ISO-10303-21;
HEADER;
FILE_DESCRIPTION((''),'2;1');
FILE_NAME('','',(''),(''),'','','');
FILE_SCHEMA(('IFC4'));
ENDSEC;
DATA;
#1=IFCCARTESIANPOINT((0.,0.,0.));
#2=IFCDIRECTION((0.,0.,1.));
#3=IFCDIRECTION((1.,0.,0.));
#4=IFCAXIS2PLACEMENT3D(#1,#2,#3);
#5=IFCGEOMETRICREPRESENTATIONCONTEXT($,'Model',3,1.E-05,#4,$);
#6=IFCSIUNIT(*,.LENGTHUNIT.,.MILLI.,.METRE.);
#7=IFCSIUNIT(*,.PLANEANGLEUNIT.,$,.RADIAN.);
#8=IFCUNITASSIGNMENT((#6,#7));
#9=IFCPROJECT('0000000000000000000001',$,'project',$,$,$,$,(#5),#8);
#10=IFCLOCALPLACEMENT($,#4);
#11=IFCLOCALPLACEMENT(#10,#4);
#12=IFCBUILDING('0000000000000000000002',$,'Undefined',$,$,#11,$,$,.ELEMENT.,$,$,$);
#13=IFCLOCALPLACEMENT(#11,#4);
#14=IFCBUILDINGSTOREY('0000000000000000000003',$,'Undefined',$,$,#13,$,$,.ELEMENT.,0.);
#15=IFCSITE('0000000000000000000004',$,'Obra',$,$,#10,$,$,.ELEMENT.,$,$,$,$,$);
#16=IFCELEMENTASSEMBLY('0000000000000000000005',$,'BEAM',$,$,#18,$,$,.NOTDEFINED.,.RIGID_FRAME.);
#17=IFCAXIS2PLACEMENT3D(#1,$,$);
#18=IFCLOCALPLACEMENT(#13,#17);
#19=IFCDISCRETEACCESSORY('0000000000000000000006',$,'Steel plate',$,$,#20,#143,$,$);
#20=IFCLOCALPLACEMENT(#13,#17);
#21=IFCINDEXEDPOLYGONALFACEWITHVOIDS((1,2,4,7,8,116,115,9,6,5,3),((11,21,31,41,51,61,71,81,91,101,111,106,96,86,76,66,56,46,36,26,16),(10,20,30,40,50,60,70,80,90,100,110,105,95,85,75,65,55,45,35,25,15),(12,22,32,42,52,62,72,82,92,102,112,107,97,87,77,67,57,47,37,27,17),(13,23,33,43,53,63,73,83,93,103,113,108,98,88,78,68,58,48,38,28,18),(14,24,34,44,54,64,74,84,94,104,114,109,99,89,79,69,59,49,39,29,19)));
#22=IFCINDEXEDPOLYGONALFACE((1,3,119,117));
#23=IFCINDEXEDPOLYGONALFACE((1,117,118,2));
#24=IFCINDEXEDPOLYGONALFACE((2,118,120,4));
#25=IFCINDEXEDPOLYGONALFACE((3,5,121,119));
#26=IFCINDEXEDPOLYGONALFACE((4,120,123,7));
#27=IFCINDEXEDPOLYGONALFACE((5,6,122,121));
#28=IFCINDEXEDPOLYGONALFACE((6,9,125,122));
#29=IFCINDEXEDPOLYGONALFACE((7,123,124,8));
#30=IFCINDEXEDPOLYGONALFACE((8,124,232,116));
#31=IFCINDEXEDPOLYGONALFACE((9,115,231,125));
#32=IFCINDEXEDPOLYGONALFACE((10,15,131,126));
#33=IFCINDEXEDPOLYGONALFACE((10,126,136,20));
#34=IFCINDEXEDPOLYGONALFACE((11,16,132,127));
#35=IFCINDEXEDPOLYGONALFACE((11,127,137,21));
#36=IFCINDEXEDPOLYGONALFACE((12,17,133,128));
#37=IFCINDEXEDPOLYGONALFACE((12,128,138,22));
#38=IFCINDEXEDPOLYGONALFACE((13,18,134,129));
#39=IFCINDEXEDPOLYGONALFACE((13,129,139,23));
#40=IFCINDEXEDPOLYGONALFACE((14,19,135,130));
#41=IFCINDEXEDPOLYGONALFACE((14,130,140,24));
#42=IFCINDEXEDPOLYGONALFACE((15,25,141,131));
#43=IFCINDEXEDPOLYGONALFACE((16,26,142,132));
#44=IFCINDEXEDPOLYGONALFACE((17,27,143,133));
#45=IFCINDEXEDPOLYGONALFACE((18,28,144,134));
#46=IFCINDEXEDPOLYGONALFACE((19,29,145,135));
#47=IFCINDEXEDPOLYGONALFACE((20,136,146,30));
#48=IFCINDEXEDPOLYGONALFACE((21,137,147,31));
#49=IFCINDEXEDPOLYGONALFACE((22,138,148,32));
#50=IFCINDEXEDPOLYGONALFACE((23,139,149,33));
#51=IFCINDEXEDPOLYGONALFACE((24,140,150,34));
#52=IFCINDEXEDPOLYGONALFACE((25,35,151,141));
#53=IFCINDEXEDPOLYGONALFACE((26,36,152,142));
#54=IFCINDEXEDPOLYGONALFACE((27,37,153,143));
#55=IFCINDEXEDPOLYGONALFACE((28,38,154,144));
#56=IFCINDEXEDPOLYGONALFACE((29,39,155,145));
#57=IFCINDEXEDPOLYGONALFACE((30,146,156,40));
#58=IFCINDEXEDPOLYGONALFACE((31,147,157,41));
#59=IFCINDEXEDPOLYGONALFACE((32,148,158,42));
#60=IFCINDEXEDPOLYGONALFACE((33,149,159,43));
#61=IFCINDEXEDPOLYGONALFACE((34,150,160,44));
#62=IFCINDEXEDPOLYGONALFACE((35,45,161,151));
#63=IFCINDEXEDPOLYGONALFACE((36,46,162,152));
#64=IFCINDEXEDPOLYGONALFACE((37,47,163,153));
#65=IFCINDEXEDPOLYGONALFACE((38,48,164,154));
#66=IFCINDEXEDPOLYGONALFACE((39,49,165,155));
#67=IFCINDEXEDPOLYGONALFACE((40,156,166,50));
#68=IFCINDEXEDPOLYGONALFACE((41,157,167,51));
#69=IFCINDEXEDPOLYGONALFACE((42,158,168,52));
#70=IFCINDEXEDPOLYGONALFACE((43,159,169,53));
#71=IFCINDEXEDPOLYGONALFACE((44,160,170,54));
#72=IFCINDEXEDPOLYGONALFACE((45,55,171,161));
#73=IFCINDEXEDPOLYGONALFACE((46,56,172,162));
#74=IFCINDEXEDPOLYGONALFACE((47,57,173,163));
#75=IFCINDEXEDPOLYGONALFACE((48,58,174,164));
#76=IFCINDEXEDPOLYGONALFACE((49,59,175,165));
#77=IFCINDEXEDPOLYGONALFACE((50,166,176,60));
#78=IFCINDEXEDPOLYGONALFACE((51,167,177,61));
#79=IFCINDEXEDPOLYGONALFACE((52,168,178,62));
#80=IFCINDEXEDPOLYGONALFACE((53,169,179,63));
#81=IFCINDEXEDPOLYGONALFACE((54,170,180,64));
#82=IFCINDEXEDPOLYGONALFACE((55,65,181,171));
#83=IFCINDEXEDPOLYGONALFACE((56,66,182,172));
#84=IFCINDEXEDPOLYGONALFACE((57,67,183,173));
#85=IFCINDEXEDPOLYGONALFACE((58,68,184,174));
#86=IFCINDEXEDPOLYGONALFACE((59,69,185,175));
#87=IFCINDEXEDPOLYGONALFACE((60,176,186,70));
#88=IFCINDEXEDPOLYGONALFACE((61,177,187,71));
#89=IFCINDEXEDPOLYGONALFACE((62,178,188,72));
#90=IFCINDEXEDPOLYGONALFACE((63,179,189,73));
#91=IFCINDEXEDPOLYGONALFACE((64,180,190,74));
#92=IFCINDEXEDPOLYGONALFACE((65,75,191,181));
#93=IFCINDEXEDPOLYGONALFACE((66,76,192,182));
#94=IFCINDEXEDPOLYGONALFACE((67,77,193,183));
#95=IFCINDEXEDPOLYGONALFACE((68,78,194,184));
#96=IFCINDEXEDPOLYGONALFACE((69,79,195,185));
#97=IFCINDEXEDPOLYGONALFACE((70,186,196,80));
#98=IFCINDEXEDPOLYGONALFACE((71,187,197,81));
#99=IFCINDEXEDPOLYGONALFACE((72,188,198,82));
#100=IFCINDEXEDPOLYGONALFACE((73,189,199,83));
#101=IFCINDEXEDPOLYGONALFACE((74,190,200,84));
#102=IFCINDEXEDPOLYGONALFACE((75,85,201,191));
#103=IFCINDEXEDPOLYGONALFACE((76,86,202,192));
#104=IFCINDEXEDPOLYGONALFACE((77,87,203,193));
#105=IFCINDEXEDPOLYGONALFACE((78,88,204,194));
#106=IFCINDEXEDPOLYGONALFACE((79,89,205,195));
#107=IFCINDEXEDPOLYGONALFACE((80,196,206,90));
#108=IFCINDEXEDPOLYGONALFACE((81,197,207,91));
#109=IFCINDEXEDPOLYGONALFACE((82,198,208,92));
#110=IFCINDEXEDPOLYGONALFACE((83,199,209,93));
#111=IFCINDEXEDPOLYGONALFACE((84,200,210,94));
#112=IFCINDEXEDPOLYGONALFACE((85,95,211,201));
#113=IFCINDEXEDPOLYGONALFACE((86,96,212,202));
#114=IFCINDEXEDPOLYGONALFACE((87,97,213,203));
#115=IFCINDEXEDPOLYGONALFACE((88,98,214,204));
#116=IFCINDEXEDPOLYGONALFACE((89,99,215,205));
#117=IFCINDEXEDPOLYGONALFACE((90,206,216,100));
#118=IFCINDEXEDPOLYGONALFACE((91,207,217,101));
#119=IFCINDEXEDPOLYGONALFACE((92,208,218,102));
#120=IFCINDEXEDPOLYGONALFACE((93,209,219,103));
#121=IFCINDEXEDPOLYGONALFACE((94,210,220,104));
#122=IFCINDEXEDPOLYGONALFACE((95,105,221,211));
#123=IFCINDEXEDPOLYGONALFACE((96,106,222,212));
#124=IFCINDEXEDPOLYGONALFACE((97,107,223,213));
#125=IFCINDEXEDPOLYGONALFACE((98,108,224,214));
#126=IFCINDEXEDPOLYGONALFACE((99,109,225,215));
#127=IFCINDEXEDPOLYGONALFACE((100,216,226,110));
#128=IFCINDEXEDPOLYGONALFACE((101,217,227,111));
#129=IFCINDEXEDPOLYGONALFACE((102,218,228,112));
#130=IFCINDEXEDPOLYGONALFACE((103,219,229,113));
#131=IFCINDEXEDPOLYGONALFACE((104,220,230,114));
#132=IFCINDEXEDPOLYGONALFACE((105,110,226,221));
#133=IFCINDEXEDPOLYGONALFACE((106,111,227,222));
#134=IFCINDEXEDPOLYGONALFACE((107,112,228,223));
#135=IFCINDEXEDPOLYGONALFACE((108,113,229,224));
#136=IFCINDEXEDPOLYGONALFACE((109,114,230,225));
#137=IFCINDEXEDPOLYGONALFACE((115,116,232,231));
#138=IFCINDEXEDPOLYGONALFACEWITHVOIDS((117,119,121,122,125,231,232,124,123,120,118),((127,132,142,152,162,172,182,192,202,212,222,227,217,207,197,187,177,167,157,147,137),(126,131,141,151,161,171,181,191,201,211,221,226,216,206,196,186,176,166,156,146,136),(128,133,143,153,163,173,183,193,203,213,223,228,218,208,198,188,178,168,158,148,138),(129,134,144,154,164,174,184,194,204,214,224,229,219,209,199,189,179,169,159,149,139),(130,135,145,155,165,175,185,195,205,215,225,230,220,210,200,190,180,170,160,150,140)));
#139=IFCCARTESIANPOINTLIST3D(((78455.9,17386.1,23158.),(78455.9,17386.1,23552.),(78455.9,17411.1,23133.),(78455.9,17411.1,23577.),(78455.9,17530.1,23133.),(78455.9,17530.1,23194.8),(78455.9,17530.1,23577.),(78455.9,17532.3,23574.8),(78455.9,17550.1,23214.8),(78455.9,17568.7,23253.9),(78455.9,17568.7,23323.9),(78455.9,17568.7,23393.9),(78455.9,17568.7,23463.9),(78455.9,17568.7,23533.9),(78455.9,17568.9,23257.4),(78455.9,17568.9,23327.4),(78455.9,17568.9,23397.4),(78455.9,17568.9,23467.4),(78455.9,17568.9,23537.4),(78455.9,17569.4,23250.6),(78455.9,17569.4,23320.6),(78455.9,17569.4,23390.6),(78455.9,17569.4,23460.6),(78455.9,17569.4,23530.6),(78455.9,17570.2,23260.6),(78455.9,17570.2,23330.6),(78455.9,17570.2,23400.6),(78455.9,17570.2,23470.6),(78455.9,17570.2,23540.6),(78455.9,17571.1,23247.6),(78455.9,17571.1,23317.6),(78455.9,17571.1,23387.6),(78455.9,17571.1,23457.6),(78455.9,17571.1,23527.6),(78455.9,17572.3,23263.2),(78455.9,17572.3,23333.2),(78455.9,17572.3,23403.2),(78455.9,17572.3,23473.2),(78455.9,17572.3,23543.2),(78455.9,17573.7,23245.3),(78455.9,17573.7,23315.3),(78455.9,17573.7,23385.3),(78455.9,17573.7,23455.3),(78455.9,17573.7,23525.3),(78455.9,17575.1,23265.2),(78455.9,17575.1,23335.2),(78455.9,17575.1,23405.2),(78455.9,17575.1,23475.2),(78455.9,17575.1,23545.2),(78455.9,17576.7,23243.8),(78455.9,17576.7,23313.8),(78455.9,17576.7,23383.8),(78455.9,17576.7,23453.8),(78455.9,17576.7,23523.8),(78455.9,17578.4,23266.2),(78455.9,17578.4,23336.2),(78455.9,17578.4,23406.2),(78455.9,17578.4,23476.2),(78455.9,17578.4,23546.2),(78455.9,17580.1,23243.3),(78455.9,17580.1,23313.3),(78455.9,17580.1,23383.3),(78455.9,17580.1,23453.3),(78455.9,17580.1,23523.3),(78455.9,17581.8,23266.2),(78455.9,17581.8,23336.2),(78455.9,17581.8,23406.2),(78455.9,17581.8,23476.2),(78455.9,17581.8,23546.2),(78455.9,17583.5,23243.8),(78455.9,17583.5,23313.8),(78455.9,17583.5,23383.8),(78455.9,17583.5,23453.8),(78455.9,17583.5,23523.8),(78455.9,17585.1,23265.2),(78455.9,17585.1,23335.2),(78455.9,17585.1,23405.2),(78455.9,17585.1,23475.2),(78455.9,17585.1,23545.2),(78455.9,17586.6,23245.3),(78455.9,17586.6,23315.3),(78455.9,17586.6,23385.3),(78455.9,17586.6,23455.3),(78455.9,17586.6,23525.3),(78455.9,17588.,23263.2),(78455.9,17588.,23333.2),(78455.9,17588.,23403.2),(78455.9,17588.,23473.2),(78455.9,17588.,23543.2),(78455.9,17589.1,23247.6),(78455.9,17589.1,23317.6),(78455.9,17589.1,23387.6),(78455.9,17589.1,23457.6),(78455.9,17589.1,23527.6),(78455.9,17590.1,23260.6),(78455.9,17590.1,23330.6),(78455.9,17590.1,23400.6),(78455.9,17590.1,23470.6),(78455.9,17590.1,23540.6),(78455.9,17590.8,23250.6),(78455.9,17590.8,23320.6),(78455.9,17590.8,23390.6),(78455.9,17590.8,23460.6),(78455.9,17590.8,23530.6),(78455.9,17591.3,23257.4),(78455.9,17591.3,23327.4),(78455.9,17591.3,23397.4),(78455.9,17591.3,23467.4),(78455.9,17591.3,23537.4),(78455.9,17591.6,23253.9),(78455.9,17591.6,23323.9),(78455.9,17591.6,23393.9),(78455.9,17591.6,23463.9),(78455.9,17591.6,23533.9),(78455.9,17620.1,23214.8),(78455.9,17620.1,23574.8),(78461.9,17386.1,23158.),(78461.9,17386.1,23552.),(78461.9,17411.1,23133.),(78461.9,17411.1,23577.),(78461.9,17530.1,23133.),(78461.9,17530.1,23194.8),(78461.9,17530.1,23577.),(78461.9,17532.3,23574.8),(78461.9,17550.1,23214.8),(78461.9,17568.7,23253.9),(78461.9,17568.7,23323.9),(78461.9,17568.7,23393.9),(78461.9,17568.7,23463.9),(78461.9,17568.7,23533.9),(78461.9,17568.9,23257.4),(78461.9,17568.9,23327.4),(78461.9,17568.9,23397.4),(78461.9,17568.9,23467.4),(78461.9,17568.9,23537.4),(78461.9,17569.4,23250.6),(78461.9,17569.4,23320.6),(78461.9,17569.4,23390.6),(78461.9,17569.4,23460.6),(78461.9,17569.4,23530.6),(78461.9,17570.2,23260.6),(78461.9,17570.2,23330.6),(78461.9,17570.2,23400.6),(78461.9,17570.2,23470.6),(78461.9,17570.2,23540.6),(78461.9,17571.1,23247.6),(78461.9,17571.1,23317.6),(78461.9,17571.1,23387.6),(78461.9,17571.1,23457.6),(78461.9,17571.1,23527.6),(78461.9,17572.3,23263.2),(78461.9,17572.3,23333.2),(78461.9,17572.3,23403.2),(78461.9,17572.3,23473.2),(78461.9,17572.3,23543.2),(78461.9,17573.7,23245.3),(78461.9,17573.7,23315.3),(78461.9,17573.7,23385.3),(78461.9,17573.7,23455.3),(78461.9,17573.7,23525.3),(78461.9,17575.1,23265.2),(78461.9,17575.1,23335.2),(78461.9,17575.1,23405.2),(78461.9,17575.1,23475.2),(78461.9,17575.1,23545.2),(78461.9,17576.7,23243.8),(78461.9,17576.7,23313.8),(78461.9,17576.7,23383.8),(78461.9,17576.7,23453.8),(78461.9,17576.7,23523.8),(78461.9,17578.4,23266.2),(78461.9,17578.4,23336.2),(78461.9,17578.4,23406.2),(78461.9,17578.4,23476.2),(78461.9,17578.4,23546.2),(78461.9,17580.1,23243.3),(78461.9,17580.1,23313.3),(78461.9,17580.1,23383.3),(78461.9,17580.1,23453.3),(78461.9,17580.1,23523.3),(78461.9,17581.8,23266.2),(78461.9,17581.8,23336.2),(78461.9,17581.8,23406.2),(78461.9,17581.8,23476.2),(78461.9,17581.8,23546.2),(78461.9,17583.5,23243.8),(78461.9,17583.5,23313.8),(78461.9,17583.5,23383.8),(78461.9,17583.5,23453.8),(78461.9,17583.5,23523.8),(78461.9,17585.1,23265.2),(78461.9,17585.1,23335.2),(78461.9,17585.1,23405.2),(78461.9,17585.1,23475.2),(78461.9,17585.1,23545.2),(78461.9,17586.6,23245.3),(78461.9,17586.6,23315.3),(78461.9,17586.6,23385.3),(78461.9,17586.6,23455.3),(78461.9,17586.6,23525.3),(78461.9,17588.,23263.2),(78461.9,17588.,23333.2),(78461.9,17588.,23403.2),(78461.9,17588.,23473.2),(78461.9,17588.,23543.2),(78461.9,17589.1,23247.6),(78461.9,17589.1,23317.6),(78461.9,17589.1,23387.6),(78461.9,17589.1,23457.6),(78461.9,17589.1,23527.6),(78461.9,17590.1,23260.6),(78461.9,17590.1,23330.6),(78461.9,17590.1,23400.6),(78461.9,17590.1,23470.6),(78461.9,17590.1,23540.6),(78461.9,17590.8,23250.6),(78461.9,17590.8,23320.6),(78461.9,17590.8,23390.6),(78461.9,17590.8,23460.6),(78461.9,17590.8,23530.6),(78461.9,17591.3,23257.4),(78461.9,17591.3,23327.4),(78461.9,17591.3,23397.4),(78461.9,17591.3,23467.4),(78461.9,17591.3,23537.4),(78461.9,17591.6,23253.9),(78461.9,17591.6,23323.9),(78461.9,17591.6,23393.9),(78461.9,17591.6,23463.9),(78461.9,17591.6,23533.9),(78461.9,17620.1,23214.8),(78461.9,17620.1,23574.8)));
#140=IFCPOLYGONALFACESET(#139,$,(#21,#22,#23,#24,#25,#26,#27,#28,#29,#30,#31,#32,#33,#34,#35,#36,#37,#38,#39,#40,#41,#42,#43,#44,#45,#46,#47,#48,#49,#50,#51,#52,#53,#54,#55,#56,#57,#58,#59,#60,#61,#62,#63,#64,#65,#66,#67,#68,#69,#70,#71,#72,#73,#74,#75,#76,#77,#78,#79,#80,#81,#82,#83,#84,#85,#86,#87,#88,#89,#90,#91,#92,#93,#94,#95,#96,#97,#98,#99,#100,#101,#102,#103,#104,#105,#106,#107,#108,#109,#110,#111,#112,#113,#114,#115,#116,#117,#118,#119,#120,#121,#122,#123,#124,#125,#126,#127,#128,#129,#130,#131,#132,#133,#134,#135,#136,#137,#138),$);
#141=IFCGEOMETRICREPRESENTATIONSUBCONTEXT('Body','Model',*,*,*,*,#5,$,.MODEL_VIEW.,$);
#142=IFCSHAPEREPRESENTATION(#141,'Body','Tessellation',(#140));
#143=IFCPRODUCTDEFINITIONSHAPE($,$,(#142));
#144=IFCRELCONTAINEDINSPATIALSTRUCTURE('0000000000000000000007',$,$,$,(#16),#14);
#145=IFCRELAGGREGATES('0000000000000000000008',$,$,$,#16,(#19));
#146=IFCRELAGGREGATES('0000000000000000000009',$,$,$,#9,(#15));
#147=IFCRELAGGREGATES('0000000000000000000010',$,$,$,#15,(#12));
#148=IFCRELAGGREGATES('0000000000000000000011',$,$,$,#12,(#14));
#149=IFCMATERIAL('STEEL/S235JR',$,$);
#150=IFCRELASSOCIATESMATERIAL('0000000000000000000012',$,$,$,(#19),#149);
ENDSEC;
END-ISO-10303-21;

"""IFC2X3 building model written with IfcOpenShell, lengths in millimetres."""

from ifc_helpers import new_model, si_unit, frame, origin_with_axes, origin_2d_with_axis, place, context, subcontext, project, spatial, polyline, circle, outline, extrude, source, transform, mapped, material, element, aggregate, save


model = new_model("IFC2X3")

# Units and contexts
model_context = context("Model", 3, precision=1e-05, world=origin_with_axes())
body_context = subcontext(model_context, "Body", "Model", "MODEL_VIEW")
ifc_project = project(units=[si_unit("LENGTHUNIT", "METRE", prefix="MILLI"), si_unit("PLANEANGLEUNIT", "RADIAN")], contexts=[model_context])

# Site, building, storey
site_placement = place(None, origin_with_axes())
site = spatial("IfcSite", under=ifc_project, at=site_placement, Name="Obra", CompositionType="ELEMENT")
building_placement = place(site_placement, origin_with_axes())
building = spatial("IfcBuilding", under=site, at=building_placement, Name="Undefined", CompositionType="ELEMENT")
storey_placement = place(building_placement, origin_with_axes())
storey = spatial("IfcBuildingStorey", under=building, at=storey_placement, Name="Undefined", CompositionType="ELEMENT", Elevation=0.0)

# Element assembly
assembly_1_placement = place(storey_placement, origin_with_axes())
assembly_1 = element("IfcElementAssembly", 1, at=assembly_1_placement, inside=storey, Name="BEAM", AssemblyPlace="NOTDEFINED", PredefinedType="RIGID_FRAME")
ifc_material_1 = material(Name="STEEL/S235JR")
shared_shape_1 = source(origin_with_axes(), body_context, "Body", "SweptSolid", [
    extrude(circle(Radius=11.5, at=origin_2d_with_axis()), frame((0.0, 3.2, 0.0), z_axis=(0.0, 1.0, 0.0), x_axis=(1.0, 0.0, 0.0)), (0.0, 0.0, 1.0), 6.2),
])

# Discrete accessory, opening
discrete_accessory_1_placement = place(assembly_1_placement, frame((78458.9, 17386.1, 23158.0), z_axis=(1.0, 0.0, 0.0), x_axis=(0.0, 0.707107, -0.707107)))
discrete_accessory_1 = element("IfcDiscreteAccessory", 2, at=discrete_accessory_1_placement, material=ifc_material_1, Name="Steel plate", context=body_context, shape_type="SweptSolid", body=[
    extrude(outline(polyline([(0.0, 0.0), (35.4, 0.0), (119.5, 84.1), (75.8, 127.8), (75.8, 156.1), (125.3, 205.6), (-129.3, 460.2), (-191.3, 398.1), (-194.5, 398.1), (-194.5, 398.1), (-278.6, 314.0), (-278.6, 278.6), (0.0, 0.0)])), frame((0.0, 0.0, -3.0), z_axis=(0.0, 0.0, 1.0), x_axis=(1.0, 0.0, 0.0)), (0.0, 0.0, 1.0), 6.0),
])
opening_1_placement = place(assembly_1_placement, frame((78465.2, 17540.1, 23574.8), z_axis=(0.0, 1.0, 0.0), x_axis=(0.0, 0.0, -1.0)))
element("IfcOpeningElement", 3, at=opening_1_placement, cuts=discrete_accessory_1, ObjectType="Opening", context=body_context, shape_type="MappedRepresentation", body=[
    mapped(shared_shape_1, transform((40.0, 0.0, 40.0))),
    mapped(shared_shape_1, transform((110.0, 0.0, 40.0))),
    mapped(shared_shape_1, transform((180.0, 0.0, 40.0))),
    mapped(shared_shape_1, transform((250.0, 0.0, 40.0))),
    mapped(shared_shape_1, transform((320.0, 0.0, 40.0))),
])
aggregate(assembly_1, [discrete_accessory_1])

save(model, "model.ifc")
